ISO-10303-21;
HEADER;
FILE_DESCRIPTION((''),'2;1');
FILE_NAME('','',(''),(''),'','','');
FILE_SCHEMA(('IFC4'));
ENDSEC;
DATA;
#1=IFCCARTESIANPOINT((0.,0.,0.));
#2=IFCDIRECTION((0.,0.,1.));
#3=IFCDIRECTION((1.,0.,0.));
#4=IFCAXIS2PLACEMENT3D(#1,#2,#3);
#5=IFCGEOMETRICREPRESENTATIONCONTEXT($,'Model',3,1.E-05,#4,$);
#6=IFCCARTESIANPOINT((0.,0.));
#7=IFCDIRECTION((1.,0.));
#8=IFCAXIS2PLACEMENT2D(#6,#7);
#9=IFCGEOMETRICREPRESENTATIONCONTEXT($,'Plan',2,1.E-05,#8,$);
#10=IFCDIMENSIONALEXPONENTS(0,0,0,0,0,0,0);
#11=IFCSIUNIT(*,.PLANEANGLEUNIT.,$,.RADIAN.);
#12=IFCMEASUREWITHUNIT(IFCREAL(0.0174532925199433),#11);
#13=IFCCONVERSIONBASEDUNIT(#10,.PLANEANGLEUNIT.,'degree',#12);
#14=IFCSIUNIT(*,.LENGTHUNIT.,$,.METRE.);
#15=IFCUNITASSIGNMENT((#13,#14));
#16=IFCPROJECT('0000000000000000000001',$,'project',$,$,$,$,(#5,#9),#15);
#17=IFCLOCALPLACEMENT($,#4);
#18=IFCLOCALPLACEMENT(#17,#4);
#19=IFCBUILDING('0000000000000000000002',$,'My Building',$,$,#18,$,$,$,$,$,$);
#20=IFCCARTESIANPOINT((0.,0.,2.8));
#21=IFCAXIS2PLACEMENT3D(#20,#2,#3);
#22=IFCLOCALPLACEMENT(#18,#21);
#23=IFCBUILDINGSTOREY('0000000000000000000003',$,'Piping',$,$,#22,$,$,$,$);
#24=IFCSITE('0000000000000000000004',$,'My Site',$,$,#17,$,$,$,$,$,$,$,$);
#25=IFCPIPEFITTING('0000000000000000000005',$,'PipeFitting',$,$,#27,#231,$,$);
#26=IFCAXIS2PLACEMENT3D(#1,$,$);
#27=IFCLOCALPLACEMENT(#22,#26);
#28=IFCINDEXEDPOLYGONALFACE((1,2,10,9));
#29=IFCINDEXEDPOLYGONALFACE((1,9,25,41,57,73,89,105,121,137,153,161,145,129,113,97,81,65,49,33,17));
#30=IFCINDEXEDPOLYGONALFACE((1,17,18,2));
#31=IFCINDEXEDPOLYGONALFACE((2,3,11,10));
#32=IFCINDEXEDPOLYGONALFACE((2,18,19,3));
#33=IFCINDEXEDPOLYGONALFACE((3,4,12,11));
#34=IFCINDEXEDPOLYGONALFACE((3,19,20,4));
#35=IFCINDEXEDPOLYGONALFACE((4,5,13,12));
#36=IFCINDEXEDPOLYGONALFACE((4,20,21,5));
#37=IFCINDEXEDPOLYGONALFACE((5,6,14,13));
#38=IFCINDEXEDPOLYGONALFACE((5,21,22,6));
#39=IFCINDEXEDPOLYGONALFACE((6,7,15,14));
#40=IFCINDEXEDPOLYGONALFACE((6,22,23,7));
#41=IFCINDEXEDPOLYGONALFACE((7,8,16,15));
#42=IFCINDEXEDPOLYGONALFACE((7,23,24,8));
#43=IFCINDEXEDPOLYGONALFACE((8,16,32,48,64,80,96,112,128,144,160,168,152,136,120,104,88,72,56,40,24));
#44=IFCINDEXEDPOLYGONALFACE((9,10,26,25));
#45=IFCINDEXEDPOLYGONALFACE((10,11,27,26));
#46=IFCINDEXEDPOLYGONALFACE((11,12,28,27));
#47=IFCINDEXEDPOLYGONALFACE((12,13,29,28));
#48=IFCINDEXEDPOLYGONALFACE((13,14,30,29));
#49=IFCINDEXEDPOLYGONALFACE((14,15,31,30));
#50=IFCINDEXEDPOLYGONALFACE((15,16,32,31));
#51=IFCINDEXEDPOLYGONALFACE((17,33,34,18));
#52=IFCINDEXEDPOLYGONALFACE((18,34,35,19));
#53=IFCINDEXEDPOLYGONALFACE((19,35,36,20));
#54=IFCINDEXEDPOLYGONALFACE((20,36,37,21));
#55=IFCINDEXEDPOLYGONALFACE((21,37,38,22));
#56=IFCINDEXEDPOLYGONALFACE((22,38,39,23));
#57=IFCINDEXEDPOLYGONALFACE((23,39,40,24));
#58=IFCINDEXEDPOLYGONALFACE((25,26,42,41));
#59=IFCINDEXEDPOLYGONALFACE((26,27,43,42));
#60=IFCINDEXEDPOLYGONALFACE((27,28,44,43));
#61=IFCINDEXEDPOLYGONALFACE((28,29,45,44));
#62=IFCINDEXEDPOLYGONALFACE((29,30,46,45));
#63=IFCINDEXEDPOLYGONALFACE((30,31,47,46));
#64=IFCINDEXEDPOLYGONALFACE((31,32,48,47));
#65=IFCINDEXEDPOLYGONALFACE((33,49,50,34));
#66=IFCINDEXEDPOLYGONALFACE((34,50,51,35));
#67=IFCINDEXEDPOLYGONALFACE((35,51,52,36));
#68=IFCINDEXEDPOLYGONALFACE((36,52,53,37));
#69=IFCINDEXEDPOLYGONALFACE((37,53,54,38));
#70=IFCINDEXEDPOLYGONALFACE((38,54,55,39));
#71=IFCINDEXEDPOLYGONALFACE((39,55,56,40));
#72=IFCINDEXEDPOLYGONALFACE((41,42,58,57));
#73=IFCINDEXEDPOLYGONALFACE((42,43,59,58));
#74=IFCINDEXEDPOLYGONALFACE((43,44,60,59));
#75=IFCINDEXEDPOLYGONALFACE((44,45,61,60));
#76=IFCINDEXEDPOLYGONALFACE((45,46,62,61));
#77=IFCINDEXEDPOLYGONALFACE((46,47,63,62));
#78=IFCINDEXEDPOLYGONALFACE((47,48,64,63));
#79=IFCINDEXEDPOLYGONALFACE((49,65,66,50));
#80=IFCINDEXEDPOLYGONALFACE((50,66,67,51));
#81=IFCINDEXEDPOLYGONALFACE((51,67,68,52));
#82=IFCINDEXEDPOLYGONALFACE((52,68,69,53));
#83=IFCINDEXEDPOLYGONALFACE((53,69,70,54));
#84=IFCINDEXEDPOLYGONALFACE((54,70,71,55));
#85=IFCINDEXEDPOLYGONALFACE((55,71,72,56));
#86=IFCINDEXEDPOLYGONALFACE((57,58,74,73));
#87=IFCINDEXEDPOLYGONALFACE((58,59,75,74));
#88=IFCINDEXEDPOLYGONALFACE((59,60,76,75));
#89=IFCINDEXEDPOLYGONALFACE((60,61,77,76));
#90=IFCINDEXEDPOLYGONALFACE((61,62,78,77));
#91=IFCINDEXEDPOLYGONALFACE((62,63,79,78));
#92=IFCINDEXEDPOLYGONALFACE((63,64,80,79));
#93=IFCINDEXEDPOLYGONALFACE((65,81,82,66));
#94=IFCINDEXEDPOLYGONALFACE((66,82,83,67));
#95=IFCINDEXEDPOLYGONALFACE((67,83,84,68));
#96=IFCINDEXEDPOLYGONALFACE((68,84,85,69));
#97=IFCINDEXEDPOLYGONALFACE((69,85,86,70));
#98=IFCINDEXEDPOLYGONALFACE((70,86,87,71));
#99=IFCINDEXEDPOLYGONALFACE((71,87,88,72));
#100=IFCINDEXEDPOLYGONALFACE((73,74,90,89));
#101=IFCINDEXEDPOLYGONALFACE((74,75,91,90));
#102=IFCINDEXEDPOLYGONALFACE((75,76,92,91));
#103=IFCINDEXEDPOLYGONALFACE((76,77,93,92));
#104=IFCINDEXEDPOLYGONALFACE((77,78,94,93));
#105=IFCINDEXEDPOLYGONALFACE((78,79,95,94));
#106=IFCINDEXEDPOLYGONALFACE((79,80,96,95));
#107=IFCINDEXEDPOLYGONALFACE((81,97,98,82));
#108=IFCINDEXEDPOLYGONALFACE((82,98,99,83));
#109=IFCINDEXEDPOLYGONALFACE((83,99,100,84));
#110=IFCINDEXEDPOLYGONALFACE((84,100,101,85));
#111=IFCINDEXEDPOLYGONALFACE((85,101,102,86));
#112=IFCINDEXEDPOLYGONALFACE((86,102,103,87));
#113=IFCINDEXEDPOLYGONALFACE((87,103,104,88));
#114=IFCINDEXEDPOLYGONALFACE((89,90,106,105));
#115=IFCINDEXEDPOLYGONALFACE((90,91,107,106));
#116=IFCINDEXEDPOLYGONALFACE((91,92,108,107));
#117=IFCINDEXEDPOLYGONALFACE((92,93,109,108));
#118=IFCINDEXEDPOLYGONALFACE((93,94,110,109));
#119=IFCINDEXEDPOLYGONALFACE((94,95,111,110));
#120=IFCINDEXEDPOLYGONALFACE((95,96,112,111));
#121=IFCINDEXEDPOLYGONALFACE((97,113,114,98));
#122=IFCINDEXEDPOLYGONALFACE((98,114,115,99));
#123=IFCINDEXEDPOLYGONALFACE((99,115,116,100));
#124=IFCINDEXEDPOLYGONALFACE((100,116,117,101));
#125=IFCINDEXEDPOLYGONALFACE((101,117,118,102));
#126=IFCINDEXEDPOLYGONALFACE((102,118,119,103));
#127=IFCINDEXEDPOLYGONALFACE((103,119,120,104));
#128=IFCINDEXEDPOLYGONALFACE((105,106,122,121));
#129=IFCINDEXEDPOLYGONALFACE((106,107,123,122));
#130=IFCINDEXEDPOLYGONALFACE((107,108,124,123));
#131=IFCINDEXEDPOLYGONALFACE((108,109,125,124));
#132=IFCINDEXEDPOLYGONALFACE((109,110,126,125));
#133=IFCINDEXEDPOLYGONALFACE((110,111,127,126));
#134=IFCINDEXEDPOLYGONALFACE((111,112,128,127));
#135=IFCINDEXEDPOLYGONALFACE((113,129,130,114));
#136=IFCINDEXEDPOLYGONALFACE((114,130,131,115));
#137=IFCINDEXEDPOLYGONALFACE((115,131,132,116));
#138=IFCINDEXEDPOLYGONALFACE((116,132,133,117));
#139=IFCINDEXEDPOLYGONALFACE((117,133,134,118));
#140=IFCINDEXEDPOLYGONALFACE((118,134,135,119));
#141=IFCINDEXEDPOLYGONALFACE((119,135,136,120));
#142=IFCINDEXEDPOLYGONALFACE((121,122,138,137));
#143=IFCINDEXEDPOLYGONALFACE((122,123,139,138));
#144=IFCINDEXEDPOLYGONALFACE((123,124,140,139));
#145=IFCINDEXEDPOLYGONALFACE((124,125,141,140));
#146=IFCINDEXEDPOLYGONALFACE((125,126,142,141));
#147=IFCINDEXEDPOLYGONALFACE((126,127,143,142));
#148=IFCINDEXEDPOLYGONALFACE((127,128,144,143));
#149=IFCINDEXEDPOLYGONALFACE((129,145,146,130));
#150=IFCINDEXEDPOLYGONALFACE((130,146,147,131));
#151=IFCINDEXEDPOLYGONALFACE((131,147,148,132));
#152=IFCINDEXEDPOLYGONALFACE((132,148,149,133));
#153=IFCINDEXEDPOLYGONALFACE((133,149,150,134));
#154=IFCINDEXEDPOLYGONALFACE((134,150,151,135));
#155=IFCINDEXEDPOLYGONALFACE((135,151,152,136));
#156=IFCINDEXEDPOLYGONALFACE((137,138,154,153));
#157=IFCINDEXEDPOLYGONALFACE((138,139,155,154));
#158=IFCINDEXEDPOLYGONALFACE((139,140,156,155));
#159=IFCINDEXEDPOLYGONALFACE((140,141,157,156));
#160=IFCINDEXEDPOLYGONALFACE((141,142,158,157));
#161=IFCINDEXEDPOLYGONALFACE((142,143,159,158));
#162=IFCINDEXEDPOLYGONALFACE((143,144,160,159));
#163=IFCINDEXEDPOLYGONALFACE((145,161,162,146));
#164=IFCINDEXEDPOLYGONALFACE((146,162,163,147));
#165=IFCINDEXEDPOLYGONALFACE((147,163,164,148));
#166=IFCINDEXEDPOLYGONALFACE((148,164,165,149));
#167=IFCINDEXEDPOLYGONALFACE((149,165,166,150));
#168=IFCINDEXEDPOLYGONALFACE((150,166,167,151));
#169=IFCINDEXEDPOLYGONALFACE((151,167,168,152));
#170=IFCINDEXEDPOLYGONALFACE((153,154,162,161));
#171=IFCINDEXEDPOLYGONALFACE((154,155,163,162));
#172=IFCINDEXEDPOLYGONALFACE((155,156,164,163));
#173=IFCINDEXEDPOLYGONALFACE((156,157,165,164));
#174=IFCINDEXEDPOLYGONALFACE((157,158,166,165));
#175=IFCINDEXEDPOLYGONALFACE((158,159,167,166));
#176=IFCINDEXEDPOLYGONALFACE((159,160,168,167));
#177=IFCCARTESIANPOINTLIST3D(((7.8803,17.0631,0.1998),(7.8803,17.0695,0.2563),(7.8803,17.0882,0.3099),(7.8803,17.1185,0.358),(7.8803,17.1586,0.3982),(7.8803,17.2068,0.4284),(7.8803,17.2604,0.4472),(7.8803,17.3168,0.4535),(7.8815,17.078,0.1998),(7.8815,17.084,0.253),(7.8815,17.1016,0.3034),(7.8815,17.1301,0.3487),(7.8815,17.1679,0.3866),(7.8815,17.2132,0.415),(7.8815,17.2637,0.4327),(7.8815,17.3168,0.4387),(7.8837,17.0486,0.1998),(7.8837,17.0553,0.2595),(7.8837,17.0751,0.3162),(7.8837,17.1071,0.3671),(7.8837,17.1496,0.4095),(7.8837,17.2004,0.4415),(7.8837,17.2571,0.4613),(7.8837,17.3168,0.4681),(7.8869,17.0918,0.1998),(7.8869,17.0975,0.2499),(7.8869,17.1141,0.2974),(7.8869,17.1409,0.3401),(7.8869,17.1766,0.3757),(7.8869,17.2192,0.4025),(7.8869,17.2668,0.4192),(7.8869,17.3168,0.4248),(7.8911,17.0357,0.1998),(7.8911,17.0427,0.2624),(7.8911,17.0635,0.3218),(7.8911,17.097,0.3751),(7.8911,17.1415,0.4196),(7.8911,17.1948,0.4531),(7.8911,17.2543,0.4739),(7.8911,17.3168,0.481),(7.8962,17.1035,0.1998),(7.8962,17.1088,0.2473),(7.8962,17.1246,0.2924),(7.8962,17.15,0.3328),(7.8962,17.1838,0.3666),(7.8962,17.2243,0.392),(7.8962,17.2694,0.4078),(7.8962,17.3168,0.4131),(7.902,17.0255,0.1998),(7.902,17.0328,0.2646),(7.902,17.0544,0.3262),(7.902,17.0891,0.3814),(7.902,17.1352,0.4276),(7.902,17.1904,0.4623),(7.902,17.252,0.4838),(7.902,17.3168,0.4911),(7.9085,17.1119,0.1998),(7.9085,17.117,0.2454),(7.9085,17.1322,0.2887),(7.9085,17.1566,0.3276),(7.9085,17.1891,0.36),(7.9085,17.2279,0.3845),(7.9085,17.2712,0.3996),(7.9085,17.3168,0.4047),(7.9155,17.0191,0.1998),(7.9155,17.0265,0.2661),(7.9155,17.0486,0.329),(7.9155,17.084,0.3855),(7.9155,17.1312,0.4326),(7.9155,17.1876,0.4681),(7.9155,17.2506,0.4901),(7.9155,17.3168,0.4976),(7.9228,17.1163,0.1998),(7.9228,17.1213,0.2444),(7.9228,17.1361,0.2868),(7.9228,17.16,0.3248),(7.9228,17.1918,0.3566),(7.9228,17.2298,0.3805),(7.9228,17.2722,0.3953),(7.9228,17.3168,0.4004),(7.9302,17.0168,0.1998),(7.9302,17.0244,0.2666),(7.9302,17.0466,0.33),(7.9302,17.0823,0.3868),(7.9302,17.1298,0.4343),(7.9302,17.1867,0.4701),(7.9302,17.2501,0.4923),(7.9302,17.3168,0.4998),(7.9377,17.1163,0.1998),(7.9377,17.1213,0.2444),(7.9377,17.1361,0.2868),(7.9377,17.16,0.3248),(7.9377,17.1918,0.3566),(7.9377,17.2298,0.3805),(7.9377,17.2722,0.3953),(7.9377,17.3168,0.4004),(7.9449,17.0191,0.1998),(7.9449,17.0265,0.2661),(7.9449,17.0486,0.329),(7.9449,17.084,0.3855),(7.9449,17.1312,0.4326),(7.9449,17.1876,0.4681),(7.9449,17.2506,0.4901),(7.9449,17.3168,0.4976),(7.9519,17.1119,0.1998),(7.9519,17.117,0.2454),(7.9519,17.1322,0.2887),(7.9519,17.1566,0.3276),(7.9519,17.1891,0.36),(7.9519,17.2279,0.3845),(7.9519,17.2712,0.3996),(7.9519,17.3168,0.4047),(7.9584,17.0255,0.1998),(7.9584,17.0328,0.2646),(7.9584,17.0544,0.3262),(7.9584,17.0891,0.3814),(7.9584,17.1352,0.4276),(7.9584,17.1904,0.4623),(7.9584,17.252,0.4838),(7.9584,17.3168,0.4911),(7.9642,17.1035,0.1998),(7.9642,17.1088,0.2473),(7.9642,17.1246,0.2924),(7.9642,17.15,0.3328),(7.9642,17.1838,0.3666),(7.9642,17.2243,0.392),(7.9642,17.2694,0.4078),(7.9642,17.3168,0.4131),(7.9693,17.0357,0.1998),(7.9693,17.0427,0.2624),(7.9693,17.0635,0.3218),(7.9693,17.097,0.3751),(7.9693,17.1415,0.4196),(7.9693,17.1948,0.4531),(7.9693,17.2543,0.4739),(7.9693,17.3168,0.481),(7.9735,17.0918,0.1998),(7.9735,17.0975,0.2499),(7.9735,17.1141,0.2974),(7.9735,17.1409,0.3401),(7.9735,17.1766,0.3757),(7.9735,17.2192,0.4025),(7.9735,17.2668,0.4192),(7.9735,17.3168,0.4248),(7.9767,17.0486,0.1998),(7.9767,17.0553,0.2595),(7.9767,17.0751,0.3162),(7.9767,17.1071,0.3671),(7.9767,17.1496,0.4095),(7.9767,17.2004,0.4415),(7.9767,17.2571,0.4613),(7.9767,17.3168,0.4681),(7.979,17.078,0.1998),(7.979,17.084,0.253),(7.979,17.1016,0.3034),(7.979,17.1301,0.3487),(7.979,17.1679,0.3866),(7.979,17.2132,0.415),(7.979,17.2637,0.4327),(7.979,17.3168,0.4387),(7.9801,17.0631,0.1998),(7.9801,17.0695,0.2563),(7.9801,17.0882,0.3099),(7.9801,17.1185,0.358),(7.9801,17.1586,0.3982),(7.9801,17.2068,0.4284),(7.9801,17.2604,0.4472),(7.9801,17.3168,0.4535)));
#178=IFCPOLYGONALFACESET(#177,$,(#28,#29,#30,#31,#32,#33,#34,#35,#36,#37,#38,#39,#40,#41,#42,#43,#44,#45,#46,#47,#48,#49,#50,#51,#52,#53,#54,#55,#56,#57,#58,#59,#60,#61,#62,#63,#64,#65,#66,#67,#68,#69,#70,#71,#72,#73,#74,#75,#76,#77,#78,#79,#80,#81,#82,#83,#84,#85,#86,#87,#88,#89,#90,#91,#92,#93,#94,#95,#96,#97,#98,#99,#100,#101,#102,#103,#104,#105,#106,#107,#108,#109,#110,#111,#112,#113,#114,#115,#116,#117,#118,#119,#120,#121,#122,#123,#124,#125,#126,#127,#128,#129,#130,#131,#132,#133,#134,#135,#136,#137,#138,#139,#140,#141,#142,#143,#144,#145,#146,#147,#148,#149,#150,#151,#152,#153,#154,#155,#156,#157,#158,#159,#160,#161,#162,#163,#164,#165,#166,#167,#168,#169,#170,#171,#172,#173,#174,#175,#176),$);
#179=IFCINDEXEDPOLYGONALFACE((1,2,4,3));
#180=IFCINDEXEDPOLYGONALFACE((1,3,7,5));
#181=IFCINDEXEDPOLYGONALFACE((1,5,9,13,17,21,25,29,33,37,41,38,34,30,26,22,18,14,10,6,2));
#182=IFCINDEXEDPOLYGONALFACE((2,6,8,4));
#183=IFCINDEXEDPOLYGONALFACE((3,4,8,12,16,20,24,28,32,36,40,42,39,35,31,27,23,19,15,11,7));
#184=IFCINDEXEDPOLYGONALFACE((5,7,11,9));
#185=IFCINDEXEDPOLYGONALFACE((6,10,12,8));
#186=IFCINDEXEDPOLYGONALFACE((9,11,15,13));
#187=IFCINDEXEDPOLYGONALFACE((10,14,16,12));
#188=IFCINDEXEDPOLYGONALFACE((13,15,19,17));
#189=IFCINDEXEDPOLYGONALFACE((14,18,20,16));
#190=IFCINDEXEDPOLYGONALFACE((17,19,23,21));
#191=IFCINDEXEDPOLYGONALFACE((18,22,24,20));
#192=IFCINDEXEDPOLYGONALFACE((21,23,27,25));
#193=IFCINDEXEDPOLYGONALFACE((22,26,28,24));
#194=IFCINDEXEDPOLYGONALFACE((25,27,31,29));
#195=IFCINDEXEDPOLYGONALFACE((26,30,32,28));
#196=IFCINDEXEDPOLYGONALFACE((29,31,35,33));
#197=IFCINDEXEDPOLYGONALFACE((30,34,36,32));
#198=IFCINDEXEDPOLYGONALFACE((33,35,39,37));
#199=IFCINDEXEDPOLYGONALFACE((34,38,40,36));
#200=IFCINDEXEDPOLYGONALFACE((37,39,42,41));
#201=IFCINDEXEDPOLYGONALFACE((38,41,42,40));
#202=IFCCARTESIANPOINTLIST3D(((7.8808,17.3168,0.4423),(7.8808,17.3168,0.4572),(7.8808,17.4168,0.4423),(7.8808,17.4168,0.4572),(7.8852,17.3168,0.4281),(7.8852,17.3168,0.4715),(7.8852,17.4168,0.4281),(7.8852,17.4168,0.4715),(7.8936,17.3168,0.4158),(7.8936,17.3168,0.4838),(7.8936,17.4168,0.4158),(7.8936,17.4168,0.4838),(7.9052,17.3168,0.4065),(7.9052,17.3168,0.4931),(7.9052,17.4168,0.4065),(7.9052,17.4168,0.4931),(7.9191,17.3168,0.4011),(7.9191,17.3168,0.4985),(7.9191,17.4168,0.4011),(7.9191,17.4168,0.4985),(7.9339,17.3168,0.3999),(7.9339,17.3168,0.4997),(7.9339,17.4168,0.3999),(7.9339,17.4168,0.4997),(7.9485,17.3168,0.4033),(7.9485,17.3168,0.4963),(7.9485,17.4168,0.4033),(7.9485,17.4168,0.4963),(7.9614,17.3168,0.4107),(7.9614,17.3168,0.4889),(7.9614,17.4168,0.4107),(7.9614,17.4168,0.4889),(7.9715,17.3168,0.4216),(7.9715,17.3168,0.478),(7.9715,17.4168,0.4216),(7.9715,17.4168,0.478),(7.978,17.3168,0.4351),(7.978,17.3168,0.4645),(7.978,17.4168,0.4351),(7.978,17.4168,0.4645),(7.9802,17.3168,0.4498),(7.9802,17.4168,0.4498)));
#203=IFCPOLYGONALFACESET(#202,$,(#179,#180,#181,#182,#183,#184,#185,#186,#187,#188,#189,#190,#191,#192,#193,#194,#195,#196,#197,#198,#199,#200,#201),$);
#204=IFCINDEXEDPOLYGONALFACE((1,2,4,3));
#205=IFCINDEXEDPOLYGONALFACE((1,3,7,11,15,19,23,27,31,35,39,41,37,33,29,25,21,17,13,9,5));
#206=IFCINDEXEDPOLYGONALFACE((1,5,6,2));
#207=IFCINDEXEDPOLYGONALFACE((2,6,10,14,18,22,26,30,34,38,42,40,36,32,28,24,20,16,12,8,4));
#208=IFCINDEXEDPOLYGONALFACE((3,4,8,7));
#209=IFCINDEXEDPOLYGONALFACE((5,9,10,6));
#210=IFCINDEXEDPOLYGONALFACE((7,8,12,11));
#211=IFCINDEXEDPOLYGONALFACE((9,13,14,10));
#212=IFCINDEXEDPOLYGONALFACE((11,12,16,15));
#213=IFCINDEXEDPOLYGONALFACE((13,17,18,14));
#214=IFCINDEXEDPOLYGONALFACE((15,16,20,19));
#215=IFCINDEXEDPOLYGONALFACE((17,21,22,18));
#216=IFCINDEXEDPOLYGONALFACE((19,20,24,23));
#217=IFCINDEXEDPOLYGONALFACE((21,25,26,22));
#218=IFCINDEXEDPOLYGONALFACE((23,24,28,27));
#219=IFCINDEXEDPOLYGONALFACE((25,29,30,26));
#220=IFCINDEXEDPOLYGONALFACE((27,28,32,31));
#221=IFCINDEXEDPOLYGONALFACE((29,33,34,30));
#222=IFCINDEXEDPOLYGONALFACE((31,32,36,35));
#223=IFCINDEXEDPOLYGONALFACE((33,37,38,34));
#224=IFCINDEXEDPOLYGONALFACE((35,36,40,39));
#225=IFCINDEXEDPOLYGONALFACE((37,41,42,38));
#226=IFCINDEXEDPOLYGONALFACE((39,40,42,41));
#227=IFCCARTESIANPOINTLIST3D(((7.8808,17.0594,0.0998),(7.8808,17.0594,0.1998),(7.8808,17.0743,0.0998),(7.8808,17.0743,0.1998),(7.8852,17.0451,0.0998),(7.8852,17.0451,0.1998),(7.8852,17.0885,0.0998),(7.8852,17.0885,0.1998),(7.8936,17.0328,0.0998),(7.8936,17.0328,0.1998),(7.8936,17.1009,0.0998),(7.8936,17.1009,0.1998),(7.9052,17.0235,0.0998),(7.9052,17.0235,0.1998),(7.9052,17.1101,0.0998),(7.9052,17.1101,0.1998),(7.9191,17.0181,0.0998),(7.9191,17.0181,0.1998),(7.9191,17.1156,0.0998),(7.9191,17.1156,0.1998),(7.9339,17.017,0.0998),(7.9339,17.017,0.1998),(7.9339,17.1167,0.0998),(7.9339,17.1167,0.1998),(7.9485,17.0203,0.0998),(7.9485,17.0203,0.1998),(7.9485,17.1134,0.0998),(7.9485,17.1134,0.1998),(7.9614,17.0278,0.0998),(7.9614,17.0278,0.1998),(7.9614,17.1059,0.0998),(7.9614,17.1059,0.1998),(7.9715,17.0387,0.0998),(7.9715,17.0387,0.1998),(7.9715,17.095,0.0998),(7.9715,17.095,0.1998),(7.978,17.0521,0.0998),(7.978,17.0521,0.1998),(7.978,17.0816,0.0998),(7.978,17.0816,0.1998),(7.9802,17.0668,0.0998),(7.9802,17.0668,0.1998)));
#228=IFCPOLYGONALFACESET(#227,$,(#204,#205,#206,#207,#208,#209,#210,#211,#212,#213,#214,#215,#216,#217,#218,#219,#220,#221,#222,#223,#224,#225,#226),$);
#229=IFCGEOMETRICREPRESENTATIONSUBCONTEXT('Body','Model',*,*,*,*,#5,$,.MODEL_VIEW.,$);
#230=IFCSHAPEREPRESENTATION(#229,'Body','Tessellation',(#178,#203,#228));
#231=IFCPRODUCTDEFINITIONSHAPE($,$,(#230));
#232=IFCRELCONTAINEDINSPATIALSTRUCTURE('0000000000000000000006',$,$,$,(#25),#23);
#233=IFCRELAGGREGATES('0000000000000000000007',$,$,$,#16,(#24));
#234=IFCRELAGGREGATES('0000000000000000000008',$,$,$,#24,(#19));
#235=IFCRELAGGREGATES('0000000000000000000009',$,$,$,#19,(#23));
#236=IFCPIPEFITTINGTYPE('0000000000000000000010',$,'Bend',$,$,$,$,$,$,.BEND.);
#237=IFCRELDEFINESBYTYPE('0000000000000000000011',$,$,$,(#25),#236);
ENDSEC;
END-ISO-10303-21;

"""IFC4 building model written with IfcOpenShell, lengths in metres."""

from ifc_helpers import new_model, entity, si_unit, converted_unit, frame, origin_with_axes, origin_2d_with_axis, place, context, subcontext, project, spatial, circle, extrude, source, transform, mapped, type_object, type_shapes, element, save


model = new_model("IFC4")

# Units and contexts
model_context = context("Model", 3, precision=1e-05, world=origin_with_axes())
plan_context = context("Plan", 2, precision=1e-05, world=origin_2d_with_axis())
body_context = subcontext(model_context, "Body", "Model", "MODEL_VIEW")
ifc_project = project(units=[converted_unit("PLANEANGLEUNIT", "degree", entity("IfcReal", 0.0174532925199433), si_unit("PLANEANGLEUNIT", "RADIAN"), dimensions=[0, 0, 0, 0, 0, 0, 0]), si_unit("LENGTHUNIT", "METRE")], contexts=[model_context, plan_context])

# Site, building, storey
site_placement = place(None, origin_with_axes())
site = spatial("IfcSite", under=ifc_project, at=site_placement, Name="My Site")
building_placement = place(site_placement, origin_with_axes())
building = spatial("IfcBuilding", under=site, at=building_placement, Name="My Building")
storey_placement = place(building_placement, frame((0.0, 0.0, 2.8), z_axis=(0.0, 0.0, 1.0), x_axis=(1.0, 0.0, 0.0)))
storey = spatial("IfcBuildingStorey", under=building, at=storey_placement, Name="Piping")

# Pipe fitting
pipe_fitting_type_1 = type_object("IfcPipeFittingType", Name="Bend", PredefinedType="BEND")
shared_shape_1 = source(origin_with_axes(), body_context, "Body", "SolidModel", [
    entity("IfcSweptDiskSolid", entity("IfcIndexedPolyCurve", entity("IfcCartesianPointList3D", [[0.0, 0.0, 0.1], [0.0, -0.0732, 0.2768], [0.0, -0.25, 0.35]]), [entity("IfcArcIndex", [1, 2, 3])]), 0.05),
    extrude(circle(Radius=0.05), origin_with_axes(), (0.0, 0.0, 1.0), 0.1),
    extrude(circle(Radius=0.05), frame((0.0, -0.25, 0.35), z_axis=(0.0, -1.0, 0.0), x_axis=(1.0, 0.0, 0.0)), (0.0, 0.0, 1.0), 0.1),
])
type_shapes(pipe_fitting_type_1, [shared_shape_1])
for number, where, z_axis, x_axis, name in (
    (1, (7.9302, 17.4168, 0.4498), (0.0, -1.0, 0.0), (1.0, 0.0, 0.0), "PipeFitting"),
):
    element("IfcPipeFitting", number, at=place(storey_placement, frame(where, z_axis=z_axis, x_axis=x_axis)), inside=storey, type_object=pipe_fitting_type_1, Name=name, context=body_context, shape_type="MappedRepresentation", body=[
        mapped(shared_shape_1, transform((0.0, 0.0, 0.0), x_axis=(1.0, 0.0, 0.0), y_axis=(0.0, 1.0, 0.0), z_axis=(0.0, 0.0, 1.0), scale=1.0)),
    ])

save(model, "model.ifc")
